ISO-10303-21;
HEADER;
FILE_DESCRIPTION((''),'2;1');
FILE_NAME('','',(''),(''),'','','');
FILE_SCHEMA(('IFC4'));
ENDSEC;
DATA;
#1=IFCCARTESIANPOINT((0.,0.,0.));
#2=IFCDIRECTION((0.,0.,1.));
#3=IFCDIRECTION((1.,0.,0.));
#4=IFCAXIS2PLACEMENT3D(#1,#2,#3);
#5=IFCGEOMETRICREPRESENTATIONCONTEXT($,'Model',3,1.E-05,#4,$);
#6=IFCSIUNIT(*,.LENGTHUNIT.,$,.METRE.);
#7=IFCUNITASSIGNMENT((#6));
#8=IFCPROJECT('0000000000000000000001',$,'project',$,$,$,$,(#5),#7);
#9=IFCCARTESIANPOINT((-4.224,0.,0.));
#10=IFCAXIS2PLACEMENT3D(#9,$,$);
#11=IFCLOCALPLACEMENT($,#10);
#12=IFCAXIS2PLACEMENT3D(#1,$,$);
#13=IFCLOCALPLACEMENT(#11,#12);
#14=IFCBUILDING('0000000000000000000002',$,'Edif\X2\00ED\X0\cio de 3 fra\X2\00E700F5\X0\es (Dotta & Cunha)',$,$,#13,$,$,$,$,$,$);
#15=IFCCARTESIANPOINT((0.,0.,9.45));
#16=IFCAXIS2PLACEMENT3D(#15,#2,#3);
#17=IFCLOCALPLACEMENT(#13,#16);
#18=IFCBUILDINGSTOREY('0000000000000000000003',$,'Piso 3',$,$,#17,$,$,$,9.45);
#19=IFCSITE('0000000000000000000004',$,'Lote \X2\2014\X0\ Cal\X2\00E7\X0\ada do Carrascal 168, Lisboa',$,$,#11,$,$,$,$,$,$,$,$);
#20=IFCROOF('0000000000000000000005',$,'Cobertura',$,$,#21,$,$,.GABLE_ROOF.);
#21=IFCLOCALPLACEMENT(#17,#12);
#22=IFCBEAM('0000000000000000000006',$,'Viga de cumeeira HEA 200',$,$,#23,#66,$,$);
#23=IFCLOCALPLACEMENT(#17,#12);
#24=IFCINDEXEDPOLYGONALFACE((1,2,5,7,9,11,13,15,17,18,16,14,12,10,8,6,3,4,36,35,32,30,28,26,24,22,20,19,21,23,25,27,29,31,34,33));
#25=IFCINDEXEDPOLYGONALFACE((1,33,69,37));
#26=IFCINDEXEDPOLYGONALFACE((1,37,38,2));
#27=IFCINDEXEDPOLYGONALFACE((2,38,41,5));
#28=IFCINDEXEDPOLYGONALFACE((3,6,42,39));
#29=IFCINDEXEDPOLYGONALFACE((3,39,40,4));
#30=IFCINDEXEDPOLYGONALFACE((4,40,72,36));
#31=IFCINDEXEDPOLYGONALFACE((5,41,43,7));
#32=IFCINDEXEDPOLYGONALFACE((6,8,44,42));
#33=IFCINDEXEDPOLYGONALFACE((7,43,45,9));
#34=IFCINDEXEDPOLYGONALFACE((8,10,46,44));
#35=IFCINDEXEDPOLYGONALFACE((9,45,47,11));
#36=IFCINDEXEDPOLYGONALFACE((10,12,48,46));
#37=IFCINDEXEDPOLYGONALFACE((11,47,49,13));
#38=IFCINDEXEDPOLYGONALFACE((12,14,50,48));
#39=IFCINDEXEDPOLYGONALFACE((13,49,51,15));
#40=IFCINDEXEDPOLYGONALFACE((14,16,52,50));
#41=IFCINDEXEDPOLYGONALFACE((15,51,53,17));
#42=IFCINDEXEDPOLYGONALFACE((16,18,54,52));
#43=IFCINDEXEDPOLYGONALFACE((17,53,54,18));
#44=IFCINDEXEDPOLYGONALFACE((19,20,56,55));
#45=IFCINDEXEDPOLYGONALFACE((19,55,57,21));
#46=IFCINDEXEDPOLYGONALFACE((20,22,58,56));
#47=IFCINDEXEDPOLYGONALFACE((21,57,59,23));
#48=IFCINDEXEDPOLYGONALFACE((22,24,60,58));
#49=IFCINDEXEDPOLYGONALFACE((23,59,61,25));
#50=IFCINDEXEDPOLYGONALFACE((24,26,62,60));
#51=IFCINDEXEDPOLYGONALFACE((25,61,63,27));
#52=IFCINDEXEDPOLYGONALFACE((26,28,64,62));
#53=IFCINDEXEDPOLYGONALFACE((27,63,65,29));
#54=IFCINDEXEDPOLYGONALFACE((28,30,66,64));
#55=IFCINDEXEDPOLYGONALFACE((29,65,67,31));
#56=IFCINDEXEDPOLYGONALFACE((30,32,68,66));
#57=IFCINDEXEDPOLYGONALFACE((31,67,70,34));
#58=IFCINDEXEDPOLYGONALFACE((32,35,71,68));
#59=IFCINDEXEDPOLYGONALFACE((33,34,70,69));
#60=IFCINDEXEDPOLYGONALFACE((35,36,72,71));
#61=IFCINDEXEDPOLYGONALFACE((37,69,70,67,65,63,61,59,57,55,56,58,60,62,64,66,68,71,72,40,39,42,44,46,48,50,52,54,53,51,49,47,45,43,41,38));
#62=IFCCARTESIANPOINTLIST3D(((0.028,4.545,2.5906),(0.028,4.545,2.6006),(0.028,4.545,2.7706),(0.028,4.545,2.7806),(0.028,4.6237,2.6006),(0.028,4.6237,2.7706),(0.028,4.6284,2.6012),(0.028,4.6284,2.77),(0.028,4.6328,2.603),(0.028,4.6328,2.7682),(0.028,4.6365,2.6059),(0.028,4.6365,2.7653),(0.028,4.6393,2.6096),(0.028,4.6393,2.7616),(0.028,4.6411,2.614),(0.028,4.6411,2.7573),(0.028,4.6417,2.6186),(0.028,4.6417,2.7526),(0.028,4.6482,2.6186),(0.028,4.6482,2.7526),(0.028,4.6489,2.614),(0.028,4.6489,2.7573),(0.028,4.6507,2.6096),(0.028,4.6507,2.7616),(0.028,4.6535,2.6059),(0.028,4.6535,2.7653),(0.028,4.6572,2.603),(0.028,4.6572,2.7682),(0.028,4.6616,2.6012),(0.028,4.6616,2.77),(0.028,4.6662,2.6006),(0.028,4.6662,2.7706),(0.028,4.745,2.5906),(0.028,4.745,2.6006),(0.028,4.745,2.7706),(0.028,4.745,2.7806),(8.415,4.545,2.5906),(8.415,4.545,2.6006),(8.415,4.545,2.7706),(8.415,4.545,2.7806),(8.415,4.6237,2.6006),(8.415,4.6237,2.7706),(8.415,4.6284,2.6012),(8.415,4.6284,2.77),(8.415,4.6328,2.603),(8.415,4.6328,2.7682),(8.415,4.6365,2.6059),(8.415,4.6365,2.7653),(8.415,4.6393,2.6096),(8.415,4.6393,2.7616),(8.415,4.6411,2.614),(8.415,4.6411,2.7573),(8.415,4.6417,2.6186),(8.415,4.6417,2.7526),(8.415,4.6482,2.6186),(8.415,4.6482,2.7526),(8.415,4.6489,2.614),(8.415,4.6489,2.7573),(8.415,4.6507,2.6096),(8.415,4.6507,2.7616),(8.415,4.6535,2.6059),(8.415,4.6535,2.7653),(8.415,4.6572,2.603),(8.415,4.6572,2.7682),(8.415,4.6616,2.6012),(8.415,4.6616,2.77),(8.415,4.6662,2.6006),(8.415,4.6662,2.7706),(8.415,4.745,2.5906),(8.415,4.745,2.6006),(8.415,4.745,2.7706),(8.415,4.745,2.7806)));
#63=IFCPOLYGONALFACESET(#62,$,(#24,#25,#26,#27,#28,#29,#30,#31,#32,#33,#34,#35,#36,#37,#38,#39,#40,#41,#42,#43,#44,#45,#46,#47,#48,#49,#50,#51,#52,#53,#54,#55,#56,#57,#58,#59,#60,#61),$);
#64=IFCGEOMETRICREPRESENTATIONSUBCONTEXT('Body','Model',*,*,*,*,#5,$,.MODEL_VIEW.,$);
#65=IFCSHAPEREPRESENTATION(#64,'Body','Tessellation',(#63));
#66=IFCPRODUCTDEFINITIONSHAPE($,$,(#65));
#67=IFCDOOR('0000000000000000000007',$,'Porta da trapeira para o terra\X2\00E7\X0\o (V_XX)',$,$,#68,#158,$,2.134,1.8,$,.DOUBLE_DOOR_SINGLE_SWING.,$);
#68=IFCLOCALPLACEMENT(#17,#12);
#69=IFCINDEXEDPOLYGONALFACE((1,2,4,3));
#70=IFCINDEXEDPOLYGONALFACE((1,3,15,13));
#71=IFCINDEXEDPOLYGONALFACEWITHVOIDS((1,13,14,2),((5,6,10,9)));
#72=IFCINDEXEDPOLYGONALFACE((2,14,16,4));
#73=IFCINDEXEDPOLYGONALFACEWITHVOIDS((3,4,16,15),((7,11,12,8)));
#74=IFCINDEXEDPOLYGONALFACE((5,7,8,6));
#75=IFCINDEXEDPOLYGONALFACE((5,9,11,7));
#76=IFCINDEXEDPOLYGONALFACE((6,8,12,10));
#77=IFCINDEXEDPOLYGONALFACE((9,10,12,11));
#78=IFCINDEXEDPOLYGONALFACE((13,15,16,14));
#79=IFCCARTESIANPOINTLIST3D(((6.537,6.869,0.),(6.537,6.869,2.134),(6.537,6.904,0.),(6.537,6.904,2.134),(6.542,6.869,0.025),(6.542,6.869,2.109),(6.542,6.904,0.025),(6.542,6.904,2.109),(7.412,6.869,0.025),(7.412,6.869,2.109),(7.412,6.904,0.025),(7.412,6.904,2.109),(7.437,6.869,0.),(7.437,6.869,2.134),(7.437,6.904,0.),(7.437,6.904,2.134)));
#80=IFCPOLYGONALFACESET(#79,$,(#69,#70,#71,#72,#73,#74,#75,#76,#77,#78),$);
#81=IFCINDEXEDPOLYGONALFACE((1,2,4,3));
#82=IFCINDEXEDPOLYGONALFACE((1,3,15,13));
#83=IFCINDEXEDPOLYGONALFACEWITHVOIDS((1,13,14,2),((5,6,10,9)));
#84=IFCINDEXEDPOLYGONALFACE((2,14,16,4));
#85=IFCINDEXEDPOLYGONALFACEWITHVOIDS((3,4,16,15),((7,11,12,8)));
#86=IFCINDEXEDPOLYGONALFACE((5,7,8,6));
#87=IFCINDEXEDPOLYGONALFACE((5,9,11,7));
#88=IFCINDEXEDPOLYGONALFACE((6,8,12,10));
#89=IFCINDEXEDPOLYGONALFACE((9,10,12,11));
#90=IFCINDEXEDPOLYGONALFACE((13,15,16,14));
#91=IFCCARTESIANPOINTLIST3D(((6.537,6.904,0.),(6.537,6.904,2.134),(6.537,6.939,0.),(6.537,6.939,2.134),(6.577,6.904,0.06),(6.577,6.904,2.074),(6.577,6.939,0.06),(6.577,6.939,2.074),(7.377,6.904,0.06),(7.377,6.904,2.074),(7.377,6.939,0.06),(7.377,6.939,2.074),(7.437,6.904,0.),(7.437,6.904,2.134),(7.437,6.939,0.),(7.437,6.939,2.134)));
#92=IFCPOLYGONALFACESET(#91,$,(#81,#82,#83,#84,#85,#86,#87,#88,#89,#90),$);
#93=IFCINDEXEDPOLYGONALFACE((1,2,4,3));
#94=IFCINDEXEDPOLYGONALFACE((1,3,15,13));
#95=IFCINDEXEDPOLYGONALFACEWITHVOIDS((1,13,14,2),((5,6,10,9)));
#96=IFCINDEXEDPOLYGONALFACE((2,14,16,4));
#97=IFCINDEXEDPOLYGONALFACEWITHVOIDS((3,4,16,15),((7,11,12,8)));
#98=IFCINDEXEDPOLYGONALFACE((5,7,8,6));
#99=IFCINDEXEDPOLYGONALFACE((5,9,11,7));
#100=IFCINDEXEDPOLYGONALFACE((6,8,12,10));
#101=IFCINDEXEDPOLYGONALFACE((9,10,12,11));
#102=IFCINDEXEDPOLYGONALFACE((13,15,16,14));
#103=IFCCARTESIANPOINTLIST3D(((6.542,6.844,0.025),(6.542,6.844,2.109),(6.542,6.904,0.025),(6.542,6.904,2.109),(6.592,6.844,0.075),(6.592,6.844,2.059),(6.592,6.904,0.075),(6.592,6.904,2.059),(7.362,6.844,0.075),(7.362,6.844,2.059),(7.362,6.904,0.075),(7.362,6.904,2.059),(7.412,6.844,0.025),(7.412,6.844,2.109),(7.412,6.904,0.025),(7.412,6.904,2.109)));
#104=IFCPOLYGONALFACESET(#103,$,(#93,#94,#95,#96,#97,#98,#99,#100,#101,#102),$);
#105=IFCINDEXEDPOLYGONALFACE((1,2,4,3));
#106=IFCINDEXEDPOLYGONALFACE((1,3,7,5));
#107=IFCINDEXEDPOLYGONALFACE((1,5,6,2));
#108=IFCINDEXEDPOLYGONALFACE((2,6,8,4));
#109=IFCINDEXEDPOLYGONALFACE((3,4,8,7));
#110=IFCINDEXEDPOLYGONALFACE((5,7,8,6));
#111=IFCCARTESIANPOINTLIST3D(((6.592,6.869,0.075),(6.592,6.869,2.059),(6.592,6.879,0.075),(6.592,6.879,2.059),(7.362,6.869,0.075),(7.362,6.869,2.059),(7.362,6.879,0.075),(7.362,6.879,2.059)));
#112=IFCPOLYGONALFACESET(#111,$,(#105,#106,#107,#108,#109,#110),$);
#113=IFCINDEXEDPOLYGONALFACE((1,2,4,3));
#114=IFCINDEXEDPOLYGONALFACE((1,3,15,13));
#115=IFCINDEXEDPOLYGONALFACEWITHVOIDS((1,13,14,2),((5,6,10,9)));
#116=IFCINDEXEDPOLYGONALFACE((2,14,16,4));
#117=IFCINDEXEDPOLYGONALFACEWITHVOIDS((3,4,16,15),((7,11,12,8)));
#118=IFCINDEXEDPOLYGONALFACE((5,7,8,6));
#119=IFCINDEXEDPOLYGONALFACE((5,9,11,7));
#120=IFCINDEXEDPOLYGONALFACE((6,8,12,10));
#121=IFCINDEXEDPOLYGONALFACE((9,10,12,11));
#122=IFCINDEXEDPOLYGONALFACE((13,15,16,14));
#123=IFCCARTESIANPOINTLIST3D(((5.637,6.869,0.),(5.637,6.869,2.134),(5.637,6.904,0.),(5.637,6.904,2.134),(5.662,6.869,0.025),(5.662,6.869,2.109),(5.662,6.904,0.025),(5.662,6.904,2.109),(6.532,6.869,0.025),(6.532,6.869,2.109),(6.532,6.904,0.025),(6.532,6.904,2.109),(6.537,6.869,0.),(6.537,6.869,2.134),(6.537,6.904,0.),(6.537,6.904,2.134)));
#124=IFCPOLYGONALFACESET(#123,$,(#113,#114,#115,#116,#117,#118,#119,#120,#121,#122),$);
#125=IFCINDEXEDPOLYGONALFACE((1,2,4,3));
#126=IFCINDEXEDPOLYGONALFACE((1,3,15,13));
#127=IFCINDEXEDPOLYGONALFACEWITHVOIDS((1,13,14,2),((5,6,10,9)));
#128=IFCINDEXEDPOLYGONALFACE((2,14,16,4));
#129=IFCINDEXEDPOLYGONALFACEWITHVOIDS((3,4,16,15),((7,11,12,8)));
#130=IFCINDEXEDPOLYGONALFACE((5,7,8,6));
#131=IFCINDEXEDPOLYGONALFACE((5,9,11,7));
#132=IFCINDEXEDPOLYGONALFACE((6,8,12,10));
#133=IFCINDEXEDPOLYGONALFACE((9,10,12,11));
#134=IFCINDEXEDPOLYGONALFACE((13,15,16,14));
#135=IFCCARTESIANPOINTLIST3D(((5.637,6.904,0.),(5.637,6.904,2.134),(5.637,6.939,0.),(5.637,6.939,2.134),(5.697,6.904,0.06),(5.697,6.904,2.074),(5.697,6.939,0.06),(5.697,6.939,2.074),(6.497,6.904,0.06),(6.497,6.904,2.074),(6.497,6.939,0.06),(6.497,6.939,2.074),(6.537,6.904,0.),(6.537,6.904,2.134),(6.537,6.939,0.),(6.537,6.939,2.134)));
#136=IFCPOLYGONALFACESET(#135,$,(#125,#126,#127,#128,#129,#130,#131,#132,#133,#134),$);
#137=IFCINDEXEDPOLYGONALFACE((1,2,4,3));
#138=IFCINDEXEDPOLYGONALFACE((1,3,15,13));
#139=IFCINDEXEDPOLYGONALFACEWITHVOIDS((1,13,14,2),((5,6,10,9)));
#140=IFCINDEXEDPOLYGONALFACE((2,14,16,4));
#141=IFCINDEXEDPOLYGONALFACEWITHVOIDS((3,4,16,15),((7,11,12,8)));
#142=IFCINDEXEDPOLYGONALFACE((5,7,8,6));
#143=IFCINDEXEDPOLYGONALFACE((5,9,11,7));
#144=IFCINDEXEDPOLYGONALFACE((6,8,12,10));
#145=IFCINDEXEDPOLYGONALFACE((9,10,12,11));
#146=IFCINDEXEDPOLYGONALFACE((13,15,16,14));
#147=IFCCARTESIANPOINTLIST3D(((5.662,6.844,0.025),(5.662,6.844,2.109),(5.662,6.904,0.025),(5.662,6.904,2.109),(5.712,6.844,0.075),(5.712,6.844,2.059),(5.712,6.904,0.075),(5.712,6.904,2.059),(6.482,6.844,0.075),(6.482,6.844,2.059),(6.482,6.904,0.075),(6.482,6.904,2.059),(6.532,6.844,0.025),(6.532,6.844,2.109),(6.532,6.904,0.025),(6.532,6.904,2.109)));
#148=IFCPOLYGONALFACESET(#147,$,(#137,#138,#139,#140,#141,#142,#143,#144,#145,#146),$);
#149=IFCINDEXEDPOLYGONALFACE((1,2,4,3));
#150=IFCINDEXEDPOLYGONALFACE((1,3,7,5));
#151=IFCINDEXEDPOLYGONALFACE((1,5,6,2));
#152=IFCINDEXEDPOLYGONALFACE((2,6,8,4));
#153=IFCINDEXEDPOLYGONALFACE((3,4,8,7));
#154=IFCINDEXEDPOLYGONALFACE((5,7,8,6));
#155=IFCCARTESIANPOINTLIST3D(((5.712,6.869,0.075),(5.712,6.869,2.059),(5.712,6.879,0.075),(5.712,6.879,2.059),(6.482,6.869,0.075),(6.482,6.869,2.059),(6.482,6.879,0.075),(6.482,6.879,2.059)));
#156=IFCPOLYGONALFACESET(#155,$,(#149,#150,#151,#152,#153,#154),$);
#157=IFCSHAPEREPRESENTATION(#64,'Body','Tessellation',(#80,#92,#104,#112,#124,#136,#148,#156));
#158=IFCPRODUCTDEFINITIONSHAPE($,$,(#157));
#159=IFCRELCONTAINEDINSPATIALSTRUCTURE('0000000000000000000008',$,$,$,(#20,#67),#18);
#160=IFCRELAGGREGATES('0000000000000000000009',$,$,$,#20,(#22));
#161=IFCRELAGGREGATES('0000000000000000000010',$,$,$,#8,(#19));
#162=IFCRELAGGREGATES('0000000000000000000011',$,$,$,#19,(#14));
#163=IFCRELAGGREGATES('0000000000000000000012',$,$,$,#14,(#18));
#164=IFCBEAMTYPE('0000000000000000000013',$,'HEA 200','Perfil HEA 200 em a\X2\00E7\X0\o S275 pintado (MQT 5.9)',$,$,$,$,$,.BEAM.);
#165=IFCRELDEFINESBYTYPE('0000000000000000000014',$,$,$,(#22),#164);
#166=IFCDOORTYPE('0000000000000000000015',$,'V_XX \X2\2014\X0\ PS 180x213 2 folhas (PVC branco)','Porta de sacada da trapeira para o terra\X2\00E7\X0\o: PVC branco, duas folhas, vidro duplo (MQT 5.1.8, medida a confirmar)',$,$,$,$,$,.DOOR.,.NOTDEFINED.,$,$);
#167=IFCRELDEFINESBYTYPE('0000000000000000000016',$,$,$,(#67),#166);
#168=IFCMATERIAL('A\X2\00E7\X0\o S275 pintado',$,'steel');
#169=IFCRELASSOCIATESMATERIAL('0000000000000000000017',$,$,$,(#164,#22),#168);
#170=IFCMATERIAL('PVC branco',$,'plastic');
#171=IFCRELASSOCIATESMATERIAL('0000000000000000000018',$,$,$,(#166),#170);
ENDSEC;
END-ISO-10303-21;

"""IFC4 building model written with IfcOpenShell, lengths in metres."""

from ifc_helpers import new_model, si_unit, frame, origin, origin_with_axes, place, context, subcontext, project, spatial, line, indexed_curve, i_section, outline, extrude, source, transform, mapped, material, type_object, type_shapes, element, aggregate, save


model = new_model("IFC4")

# Units and contexts
model_context = context("Model", 3, precision=1e-05, world=origin_with_axes())
body_context = subcontext(model_context, "Body", "Model", "MODEL_VIEW")
ifc_project = project(units=[si_unit("LENGTHUNIT", "METRE")], contexts=[model_context])

# Site, building, storey
site_placement = place(None, frame((-4.224, 0.0, 0.0)))
site = spatial("IfcSite", under=ifc_project, at=site_placement, Name="Lote — Calçada do Carrascal 168, Lisboa")
building_placement = place(site_placement, origin())
building = spatial("IfcBuilding", under=site, at=building_placement, Name="Edifício de 3 frações (Dotta & Cunha)")
storey_placement = place(building_placement, frame((0.0, 0.0, 9.45), z_axis=(0.0, 0.0, 1.0), x_axis=(1.0, 0.0, 0.0)))
storey = spatial("IfcBuildingStorey", under=building, at=storey_placement, Name="Piso 3", Elevation=9.45)

# Roof
roof_placement = place(storey_placement, frame((0.0, 0.0, -9.45), z_axis=(0.0, 0.0, 1.0), x_axis=(1.0, 0.0, 0.0)))
roof = element("IfcRoof", 1, at=roof_placement, inside=storey, Name="Cobertura", PredefinedType="GABLE_ROOF")
ifc_material_1 = material(Name="Aço S275 pintado", Category="steel")

# Beam
beam_type_1 = type_object("IfcBeamType", Name="HEA 200", Description="Perfil HEA 200 em aço S275 pintado (MQT 5.9)", PredefinedType="BEAM", material=ifc_material_1)
beam_1_placement = place(roof_placement, frame((0.028, 4.645, 12.1356), z_axis=(1.0, 0.0, 0.0), x_axis=(0.0, 1.0, 0.0)))
beam_1 = element("IfcBeam", 2, at=beam_1_placement, type_object=beam_type_1, material=ifc_material_1, Name="Viga de cumeeira HEA 200", context=body_context, shape_type="SweptSolid", body=[
    extrude(i_section(OverallWidth=0.2, OverallDepth=0.19, WebThickness=0.0065, FlangeThickness=0.01, FilletRadius=0.018), None, (0.0, 0.0, 1.0), 8.387),
])
aggregate(roof, [beam_1])

# Door
ifc_material_2 = material(Name="PVC branco", Category="plastic")
door_type = type_object("IfcDoorType", Name="V_XX — PS 180x213 2 folhas (PVC branco)", Description="Porta de sacada da trapeira para o terraço: PVC branco, duas folhas, vidro duplo (MQT 5.1.8, medida a confirmar)", OperationType="NOTDEFINED", PredefinedType="DOOR", material=ifc_material_2)
shared_shape = source(origin_with_axes(), body_context, "Body", "SweptSolid", [
    extrude(outline(indexed_curve([(0.0, 0.0), (0.9, 0.0), (0.9, 2.134), (0.0, 2.134)], segments=[line(1, 2, 3, 4, 1)]), holes=[indexed_curve([(0.025, 0.025), (0.895, 0.025), (0.895, 2.109), (0.025, 2.109)], segments=[line(1, 2, 3, 4, 1)])]), frame((0.0, 0.035, 0.0), z_axis=(0.0, -1.0, 0.0), x_axis=(1.0, 0.0, 0.0)), (0.0, 0.0, -1.0), 0.035),
    extrude(outline(indexed_curve([(0.0, 0.0), (0.9, 0.0), (0.9, 2.134), (0.0, 2.134)], segments=[line(1, 2, 3, 4, 1)]), holes=[indexed_curve([(0.06, 0.06), (0.86, 0.06), (0.86, 2.074), (0.06, 2.074)], segments=[line(1, 2, 3, 4, 1)])]), frame((0.0, 0.0, 0.0), z_axis=(0.0, -1.0, 0.0), x_axis=(1.0, 0.0, 0.0)), (0.0, 0.0, -1.0), 0.035),
    extrude(outline(indexed_curve([(0.0, 0.0), (0.87, 0.0), (0.87, 2.084), (0.0, 2.084)], segments=[line(1, 2, 3, 4, 1)]), holes=[indexed_curve([(0.05, 0.05), (0.82, 0.05), (0.82, 2.034), (0.05, 2.034)], segments=[line(1, 2, 3, 4, 1)])]), frame((0.025, 0.035, 0.025), z_axis=(0.0, -1.0, 0.0), x_axis=(1.0, 0.0, 0.0)), (0.0, 0.0, -1.0), 0.06),
    extrude(outline(indexed_curve([(0.05, 0.05), (0.82, 0.05), (0.82, 2.034), (0.05, 2.034)], segments=[line(1, 2, 3, 4, 1)])), frame((0.025, 0.06, 0.025), z_axis=(0.0, -1.0, 0.0), x_axis=(1.0, 0.0, 0.0)), (0.0, 0.0, -1.0), 0.01),
    extrude(outline(indexed_curve([(0.0, 0.0), (0.9, 0.0), (0.9, 2.134), (0.0, 2.134)], segments=[line(1, 2, 3, 4, 1)]), holes=[indexed_curve([(0.005, 0.025), (0.875, 0.025), (0.875, 2.109), (0.005, 2.109)], segments=[line(1, 2, 3, 4, 1)])]), frame((0.9, 0.035, 0.0), z_axis=(0.0, -1.0, 0.0), x_axis=(1.0, 0.0, 0.0)), (0.0, 0.0, -1.0), 0.035),
    extrude(outline(indexed_curve([(0.0, 0.0), (0.9, 0.0), (0.9, 2.134), (0.0, 2.134)], segments=[line(1, 2, 3, 4, 1)]), holes=[indexed_curve([(0.04, 0.06), (0.84, 0.06), (0.84, 2.074), (0.04, 2.074)], segments=[line(1, 2, 3, 4, 1)])]), frame((0.9, 0.0, 0.0), z_axis=(0.0, -1.0, 0.0), x_axis=(1.0, 0.0, 0.0)), (0.0, 0.0, -1.0), 0.035),
    extrude(outline(indexed_curve([(0.0, 0.0), (0.87, 0.0), (0.87, 2.084), (0.0, 2.084)], segments=[line(1, 2, 3, 4, 1)]), holes=[indexed_curve([(0.05, 0.05), (0.82, 0.05), (0.82, 2.034), (0.05, 2.034)], segments=[line(1, 2, 3, 4, 1)])]), frame((0.905, 0.035, 0.025), z_axis=(0.0, -1.0, 0.0), x_axis=(1.0, 0.0, 0.0)), (0.0, 0.0, -1.0), 0.06),
    extrude(outline(indexed_curve([(0.05, 0.05), (0.82, 0.05), (0.82, 2.034), (0.05, 2.034)], segments=[line(1, 2, 3, 4, 1)])), frame((0.905, 0.06, 0.025), z_axis=(0.0, -1.0, 0.0), x_axis=(1.0, 0.0, 0.0)), (0.0, 0.0, -1.0), 0.01),
])
type_shapes(door_type, [shared_shape])
door_placement = place(storey_placement, frame((7.437, 6.939, 0.0), z_axis=(0.0, 0.0, 1.0), x_axis=(-1.0, 0.0, 0.0)))
element("IfcDoor", 3, at=door_placement, inside=storey, type_object=door_type, Name="Porta da trapeira para o terraço (V_XX)", OperationType="DOUBLE_DOOR_SINGLE_SWING", OverallHeight=2.134, OverallWidth=1.8, context=body_context, shape_type="MappedRepresentation", body=[
    mapped(shared_shape, transform((0.0, 0.0, 0.0), x_axis=(1.0, 0.0, 0.0), y_axis=(0.0, 1.0, 0.0), z_axis=(0.0, 0.0, 1.0), scale=1.0)),
])

save(model, "model.ifc")
